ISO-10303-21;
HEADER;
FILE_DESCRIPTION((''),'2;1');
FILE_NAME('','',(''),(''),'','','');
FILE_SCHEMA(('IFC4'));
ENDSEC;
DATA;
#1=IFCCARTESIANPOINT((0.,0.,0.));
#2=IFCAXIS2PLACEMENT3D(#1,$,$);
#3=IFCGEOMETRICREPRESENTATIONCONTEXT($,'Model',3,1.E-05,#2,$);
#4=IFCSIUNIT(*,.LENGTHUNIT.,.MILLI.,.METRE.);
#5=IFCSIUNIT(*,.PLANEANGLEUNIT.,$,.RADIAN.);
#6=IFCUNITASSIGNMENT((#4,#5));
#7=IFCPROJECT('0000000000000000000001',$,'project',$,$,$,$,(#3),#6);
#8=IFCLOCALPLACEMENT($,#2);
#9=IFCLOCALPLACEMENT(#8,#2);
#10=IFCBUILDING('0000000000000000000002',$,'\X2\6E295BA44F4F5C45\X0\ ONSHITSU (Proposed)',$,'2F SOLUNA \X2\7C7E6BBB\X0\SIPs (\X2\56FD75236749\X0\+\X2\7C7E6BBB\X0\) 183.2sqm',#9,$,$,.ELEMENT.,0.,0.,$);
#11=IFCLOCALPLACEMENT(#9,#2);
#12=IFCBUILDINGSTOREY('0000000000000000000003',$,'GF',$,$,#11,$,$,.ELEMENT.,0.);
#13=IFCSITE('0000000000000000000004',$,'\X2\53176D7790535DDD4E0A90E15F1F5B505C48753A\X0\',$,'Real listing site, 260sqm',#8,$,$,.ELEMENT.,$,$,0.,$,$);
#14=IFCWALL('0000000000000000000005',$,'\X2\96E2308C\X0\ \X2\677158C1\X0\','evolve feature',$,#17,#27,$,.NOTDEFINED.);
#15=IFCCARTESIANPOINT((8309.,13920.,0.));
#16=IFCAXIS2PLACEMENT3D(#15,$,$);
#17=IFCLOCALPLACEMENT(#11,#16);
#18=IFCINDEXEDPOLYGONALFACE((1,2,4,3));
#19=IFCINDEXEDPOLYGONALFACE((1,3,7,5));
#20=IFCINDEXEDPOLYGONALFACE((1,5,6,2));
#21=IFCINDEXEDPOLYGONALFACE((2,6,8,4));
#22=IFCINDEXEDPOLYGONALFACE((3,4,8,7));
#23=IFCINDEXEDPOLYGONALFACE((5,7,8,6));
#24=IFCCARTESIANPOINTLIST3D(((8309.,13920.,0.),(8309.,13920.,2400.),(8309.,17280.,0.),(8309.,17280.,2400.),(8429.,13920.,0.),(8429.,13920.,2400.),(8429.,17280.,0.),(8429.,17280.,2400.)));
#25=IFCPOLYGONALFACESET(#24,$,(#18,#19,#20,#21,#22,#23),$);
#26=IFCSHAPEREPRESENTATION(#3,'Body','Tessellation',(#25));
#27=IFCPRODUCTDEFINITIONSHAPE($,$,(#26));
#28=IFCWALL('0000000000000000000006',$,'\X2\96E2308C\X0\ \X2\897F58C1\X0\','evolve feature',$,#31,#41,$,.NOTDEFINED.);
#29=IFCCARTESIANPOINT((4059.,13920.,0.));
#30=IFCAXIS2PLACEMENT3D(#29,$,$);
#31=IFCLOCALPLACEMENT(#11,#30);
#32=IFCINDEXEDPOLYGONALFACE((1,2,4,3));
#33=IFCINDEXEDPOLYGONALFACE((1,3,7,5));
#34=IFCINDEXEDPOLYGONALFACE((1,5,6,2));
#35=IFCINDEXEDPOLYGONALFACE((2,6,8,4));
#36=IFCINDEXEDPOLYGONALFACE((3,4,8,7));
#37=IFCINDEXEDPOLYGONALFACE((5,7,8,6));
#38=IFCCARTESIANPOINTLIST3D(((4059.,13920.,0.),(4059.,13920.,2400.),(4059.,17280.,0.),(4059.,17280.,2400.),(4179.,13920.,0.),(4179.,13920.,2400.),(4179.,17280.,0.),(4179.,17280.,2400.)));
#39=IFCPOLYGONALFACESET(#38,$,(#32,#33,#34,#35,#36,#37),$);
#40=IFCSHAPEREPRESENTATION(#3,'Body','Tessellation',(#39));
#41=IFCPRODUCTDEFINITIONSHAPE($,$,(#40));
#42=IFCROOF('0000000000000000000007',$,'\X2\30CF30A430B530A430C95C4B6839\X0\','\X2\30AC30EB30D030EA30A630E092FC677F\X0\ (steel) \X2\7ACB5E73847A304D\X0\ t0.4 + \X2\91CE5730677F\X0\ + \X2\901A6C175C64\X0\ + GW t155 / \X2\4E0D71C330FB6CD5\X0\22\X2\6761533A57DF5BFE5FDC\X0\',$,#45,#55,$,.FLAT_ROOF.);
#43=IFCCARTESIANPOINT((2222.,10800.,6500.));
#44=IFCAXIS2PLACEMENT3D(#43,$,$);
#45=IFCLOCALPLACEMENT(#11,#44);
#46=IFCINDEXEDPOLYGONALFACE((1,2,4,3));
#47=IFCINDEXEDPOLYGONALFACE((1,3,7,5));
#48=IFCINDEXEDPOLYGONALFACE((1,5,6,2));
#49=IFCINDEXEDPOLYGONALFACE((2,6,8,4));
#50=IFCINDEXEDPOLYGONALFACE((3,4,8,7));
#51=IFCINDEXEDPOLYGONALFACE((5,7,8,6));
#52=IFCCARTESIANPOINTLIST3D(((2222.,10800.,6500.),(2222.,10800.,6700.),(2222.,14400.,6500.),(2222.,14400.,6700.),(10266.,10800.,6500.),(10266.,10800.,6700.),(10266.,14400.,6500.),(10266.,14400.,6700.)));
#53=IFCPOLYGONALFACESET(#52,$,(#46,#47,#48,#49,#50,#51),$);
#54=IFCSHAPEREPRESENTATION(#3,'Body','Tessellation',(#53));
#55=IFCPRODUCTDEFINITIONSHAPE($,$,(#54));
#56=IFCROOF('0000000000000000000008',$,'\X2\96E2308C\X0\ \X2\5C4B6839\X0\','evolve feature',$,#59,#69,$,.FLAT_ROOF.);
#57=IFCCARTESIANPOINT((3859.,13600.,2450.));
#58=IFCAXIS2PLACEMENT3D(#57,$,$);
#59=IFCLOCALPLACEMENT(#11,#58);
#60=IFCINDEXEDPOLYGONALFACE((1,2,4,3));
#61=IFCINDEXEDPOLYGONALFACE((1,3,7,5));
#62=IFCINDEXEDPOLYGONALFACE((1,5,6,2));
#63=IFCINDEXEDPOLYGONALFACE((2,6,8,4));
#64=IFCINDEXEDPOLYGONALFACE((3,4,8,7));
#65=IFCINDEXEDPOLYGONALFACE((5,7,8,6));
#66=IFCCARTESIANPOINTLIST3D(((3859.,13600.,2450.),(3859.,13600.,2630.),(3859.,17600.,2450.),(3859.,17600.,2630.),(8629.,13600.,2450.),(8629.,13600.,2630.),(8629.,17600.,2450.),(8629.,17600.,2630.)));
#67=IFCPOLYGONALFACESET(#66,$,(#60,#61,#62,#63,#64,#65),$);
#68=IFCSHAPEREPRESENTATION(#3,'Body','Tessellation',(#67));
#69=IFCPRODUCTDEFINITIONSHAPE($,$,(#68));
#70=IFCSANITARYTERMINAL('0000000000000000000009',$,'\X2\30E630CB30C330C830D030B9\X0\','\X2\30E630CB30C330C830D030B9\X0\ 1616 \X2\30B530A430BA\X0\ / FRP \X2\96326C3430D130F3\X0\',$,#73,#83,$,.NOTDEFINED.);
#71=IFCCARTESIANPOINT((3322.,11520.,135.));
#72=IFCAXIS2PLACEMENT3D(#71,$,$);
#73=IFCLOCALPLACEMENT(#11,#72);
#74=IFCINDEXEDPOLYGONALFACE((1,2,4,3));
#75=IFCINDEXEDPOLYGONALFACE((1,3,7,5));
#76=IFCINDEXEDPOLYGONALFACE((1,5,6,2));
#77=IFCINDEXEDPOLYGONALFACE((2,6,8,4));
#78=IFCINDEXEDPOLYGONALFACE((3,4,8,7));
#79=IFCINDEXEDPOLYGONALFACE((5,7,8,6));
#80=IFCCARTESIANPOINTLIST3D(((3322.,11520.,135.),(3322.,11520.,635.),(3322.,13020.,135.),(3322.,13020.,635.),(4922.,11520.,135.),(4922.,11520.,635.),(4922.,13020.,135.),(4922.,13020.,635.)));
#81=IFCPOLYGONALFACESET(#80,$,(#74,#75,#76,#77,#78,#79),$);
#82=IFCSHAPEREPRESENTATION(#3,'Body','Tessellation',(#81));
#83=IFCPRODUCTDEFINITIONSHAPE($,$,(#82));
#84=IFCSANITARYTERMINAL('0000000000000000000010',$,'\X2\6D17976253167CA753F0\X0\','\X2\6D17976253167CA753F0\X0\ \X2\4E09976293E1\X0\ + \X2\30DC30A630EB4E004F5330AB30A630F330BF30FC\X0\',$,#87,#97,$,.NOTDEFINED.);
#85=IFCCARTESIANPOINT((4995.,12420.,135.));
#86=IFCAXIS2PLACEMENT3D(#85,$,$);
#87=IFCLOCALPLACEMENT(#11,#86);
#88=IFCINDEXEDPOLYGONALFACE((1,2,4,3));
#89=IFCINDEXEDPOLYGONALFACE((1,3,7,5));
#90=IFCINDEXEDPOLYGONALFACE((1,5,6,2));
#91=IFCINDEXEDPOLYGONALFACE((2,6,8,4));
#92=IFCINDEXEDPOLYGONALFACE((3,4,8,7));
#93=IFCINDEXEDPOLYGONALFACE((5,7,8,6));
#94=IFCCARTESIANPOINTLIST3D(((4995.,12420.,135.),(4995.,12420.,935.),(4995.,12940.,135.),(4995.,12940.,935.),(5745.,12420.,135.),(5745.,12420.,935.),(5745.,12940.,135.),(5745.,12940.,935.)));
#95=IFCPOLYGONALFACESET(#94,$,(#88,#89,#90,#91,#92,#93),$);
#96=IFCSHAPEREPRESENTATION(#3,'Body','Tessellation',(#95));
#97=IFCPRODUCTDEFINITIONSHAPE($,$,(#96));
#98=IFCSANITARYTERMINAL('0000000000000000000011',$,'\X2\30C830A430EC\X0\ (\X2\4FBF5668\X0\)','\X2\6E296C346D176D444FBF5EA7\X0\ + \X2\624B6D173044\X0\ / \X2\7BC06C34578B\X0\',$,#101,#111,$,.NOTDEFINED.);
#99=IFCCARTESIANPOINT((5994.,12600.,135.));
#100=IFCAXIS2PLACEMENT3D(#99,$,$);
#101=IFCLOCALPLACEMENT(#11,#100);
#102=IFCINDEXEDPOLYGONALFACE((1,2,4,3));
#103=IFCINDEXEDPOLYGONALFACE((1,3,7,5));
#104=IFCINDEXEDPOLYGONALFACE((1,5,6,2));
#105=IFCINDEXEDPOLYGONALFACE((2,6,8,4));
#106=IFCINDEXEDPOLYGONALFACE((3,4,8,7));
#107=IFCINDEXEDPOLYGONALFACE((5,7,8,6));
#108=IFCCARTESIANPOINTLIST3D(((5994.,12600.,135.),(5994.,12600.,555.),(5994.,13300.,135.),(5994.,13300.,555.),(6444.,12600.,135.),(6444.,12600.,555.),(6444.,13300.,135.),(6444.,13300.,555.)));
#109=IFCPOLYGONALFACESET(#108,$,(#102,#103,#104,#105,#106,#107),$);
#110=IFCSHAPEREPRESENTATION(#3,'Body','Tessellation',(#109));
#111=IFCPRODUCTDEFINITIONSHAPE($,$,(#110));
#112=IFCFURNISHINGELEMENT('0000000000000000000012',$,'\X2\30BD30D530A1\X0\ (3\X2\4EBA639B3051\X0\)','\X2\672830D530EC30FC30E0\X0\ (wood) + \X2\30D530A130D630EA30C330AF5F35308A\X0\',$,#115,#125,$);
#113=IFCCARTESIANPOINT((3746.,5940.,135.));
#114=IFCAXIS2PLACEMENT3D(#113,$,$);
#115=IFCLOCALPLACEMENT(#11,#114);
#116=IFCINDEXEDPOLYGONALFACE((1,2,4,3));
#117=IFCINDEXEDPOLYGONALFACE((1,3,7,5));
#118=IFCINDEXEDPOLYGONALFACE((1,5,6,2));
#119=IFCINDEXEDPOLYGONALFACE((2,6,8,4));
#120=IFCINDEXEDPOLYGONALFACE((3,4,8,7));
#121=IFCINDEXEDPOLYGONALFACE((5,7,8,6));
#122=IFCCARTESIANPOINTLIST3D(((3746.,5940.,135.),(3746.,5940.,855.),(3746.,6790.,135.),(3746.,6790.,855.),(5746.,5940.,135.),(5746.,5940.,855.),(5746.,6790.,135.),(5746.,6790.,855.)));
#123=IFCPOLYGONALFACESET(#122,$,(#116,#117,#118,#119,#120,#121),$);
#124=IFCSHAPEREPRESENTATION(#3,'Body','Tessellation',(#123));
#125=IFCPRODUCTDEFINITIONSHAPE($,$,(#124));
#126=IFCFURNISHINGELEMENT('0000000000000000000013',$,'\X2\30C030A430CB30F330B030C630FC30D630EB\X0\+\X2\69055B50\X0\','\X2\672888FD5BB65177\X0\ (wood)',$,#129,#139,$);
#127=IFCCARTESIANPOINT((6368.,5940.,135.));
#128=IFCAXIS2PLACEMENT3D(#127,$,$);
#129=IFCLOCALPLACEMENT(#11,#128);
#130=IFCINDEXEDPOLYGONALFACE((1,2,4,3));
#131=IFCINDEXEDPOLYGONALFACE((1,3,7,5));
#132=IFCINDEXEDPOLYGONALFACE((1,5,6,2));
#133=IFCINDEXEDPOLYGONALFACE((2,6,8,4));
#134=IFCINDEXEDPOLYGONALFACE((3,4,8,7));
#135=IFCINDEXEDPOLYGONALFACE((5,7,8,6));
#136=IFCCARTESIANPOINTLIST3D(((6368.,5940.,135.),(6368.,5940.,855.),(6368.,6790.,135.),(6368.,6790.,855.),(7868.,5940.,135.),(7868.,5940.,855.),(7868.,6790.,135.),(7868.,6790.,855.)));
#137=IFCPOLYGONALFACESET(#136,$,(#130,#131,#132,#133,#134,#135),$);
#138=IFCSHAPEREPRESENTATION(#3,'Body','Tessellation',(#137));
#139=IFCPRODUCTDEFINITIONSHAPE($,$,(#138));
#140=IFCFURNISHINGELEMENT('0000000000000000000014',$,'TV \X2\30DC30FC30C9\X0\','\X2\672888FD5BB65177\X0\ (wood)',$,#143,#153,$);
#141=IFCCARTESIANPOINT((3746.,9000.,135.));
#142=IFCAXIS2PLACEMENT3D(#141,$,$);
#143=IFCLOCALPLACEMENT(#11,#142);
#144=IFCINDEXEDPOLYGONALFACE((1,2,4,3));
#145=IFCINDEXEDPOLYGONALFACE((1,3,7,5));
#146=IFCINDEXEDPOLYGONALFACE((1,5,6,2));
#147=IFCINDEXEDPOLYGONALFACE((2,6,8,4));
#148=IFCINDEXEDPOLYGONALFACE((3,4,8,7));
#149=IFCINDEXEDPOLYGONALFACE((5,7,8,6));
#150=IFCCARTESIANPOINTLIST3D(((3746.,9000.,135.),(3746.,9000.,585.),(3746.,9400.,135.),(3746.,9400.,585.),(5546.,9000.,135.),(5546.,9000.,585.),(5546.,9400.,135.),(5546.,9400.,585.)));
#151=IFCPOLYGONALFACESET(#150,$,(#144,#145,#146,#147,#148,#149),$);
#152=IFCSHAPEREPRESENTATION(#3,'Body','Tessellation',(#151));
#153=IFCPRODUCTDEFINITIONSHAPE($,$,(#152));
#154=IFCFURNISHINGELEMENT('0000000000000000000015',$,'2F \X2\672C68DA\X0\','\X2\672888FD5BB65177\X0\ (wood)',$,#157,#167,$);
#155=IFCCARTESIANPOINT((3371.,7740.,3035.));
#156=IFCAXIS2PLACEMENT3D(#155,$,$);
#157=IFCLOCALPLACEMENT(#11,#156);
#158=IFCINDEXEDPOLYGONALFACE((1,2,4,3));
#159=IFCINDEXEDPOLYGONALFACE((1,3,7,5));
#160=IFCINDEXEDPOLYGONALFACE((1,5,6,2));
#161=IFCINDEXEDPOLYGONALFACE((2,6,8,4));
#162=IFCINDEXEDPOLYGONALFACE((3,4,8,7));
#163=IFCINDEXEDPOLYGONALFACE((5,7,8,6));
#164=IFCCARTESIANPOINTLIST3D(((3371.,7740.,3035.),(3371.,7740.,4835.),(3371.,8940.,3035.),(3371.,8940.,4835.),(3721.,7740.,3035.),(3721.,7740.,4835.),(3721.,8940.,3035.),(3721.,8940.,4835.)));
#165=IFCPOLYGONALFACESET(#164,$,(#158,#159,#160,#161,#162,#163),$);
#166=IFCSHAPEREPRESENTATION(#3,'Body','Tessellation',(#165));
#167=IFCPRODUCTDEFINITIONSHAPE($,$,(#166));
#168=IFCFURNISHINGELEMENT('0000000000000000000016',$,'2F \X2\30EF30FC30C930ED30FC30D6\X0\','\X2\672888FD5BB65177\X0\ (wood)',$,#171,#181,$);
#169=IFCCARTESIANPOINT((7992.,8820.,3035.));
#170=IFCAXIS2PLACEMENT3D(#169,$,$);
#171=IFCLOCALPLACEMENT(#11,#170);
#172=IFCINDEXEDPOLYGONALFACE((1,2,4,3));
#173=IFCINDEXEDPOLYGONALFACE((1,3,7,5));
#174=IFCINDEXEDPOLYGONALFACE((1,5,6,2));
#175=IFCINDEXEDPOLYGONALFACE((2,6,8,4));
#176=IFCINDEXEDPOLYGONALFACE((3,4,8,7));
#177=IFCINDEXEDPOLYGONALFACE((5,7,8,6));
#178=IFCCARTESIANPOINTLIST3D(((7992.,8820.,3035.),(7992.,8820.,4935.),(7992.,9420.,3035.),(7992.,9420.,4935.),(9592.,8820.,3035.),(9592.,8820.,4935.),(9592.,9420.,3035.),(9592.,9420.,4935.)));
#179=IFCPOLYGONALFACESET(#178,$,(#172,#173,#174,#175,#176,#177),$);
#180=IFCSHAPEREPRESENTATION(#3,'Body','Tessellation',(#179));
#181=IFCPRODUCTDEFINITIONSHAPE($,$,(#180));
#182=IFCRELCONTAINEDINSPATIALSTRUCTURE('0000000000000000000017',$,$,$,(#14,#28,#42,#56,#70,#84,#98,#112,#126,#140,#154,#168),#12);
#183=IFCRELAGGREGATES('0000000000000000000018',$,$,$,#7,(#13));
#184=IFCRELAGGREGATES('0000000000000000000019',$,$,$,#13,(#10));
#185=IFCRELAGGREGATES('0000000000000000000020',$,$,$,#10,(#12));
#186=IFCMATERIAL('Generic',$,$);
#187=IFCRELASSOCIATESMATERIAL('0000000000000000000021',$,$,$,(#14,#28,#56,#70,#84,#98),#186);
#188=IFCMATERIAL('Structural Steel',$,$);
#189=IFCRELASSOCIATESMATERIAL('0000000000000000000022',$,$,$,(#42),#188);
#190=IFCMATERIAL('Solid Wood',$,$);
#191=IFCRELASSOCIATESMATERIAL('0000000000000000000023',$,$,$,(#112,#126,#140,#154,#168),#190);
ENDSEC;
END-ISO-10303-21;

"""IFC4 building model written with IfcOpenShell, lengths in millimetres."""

from ifc_helpers import new_model, si_unit, frame, frame_2d, origin, place, context, project, spatial, rectangle, extrude, material, element, save


model = new_model("IFC4")

# Units and contexts
model_context = context("Model", 3, precision=1e-05, world=origin())
ifc_project = project(units=[si_unit("LENGTHUNIT", "METRE", prefix="MILLI"), si_unit("PLANEANGLEUNIT", "RADIAN")], contexts=[model_context])

# Site, building, storey
site_placement = place(None, origin())
site = spatial("IfcSite", under=ifc_project, at=site_placement, Name="北海道川上郡弟子屈町", ObjectType="Real listing site, 260sqm", CompositionType="ELEMENT", RefElevation=0.0)
building_placement = place(site_placement, origin())
building = spatial("IfcBuilding", under=site, at=building_placement, Name="温室住居 ONSHITSU (Proposed)", ObjectType="2F SOLUNA 籾殻SIPs (国産杉+籾殻) 183.2sqm", CompositionType="ELEMENT", ElevationOfRefHeight=0.0, ElevationOfTerrain=0.0)
storey_placement = place(building_placement, origin())
storey = spatial("IfcBuildingStorey", under=building, at=storey_placement, Name="GF", CompositionType="ELEMENT", Elevation=0.0)

# Shared definitions
ifc_material_1 = material(Name="Generic")

# Shared definitions
ifc_material_2 = material(Name="Solid Wood")

# Walls
wall_1_placement = place(storey_placement, frame((8309.0, 13920.0, 0.0)))
element("IfcWall", 1, at=wall_1_placement, inside=storey, material=ifc_material_1, Name="離れ 東壁", Description="evolve feature", PredefinedType="NOTDEFINED", context=model_context, shape_type="SweptSolid", body=[
    extrude(rectangle(XDim=120.0, YDim=3360.0, at=frame_2d((60.0, 1680.0))), frame((8309.0, 13920.0, 0.0)), (0.0, 0.0, 1.0), 2400.0),
])
wall_2_placement = place(storey_placement, frame((4059.0, 13920.0, 0.0)))
element("IfcWall", 2, at=wall_2_placement, inside=storey, material=ifc_material_1, Name="離れ 西壁", Description="evolve feature", PredefinedType="NOTDEFINED", context=model_context, shape_type="SweptSolid", body=[
    extrude(rectangle(XDim=120.0, YDim=3360.0, at=frame_2d((60.0, 1680.0))), frame((4059.0, 13920.0, 0.0)), (0.0, 0.0, 1.0), 2400.0),
])

# Roofs
ifc_material_3 = material(Name="Structural Steel")
roof_1_placement = place(storey_placement, frame((2222.0, 10800.0, 6500.0)))
element("IfcRoof", 3, at=roof_1_placement, inside=storey, material=ifc_material_3, Name="ハイサイド屋根", Description="ガルバリウム鋼板 (steel) 立平葺き t0.4 + 野地板 + 通気層 + GW t155 / 不燃・法22条区域対応", PredefinedType="FLAT_ROOF", context=model_context, shape_type="SweptSolid", body=[
    extrude(rectangle(XDim=8044.0, YDim=3600.0, at=frame_2d((4022.0, 1800.0))), frame((2222.0, 10800.0, 6500.0)), (0.0, 0.0, 1.0), 200.0),
])
roof_2_placement = place(storey_placement, frame((3859.0, 13600.0, 2450.0)))
element("IfcRoof", 4, at=roof_2_placement, inside=storey, material=ifc_material_1, Name="離れ 屋根", Description="evolve feature", PredefinedType="FLAT_ROOF", context=model_context, shape_type="SweptSolid", body=[
    extrude(rectangle(XDim=4770.0, YDim=4000.0, at=frame_2d((2385.0, 2000.0))), frame((3859.0, 13600.0, 2450.0)), (0.0, 0.0, 1.0), 180.0),
])

# Sanitary terminals
sanitary_terminal_1_placement = place(storey_placement, frame((3322.0, 11520.0, 135.0)))
element("IfcSanitaryTerminal", 5, at=sanitary_terminal_1_placement, inside=storey, material=ifc_material_1, Name="ユニットバス", Description="ユニットバス 1616 サイズ / FRP 防水パン", PredefinedType="NOTDEFINED", context=model_context, shape_type="SweptSolid", body=[
    extrude(rectangle(XDim=1600.0, YDim=1500.0, at=frame_2d((800.0, 750.0))), frame((3322.0, 11520.0, 135.0)), (0.0, 0.0, 1.0), 500.0),
])
sanitary_terminal_2_placement = place(storey_placement, frame((4995.0, 12420.0, 135.0)))
element("IfcSanitaryTerminal", 6, at=sanitary_terminal_2_placement, inside=storey, material=ifc_material_1, Name="洗面化粧台", Description="洗面化粧台 三面鏡 + ボウル一体カウンター", PredefinedType="NOTDEFINED", context=model_context, shape_type="SweptSolid", body=[
    extrude(rectangle(XDim=750.0, YDim=520.0, at=frame_2d((375.0, 260.0))), frame((4995.0, 12420.0, 135.0)), (0.0, 0.0, 1.0), 800.0),
])
sanitary_terminal_3_placement = place(storey_placement, frame((5994.0, 12600.0, 135.0)))
element("IfcSanitaryTerminal", 7, at=sanitary_terminal_3_placement, inside=storey, material=ifc_material_1, Name="トイレ (便器)", Description="温水洗浄便座 + 手洗い / 節水型", PredefinedType="NOTDEFINED", context=model_context, shape_type="SweptSolid", body=[
    extrude(rectangle(XDim=450.0, YDim=700.0, at=frame_2d((225.0, 350.0))), frame((5994.0, 12600.0, 135.0)), (0.0, 0.0, 1.0), 420.0),
])

# Furnishing elements
furnishing_1_placement = place(storey_placement, frame((3746.0, 5940.0, 135.0)))
element("IfcFurnishingElement", 8, at=furnishing_1_placement, inside=storey, material=ifc_material_2, Name="ソファ (3人掛け)", Description="木フレーム (wood) + ファブリック張り", context=model_context, shape_type="SweptSolid", body=[
    extrude(rectangle(XDim=2000.0, YDim=850.0, at=frame_2d((1000.0, 425.0))), frame((3746.0, 5940.0, 135.0)), (0.0, 0.0, 1.0), 720.0),
])
furnishing_2_placement = place(storey_placement, frame((6368.0, 5940.0, 135.0)))
element("IfcFurnishingElement", 9, at=furnishing_2_placement, inside=storey, material=ifc_material_2, Name="ダイニングテーブル+椅子", Description="木製家具 (wood)", context=model_context, shape_type="SweptSolid", body=[
    extrude(rectangle(XDim=1500.0, YDim=850.0, at=frame_2d((750.0, 425.0))), frame((6368.0, 5940.0, 135.0)), (0.0, 0.0, 1.0), 720.0),
])
furnishing_3_placement = place(storey_placement, frame((3746.0, 9000.0, 135.0)))
element("IfcFurnishingElement", 10, at=furnishing_3_placement, inside=storey, material=ifc_material_2, Name="TV ボード", Description="木製家具 (wood)", context=model_context, shape_type="SweptSolid", body=[
    extrude(rectangle(XDim=1800.0, YDim=400.0, at=frame_2d((900.0, 200.0))), frame((3746.0, 9000.0, 135.0)), (0.0, 0.0, 1.0), 450.0),
])
furnishing_4_placement = place(storey_placement, frame((3371.0, 7740.0, 3035.0)))
element("IfcFurnishingElement", 11, at=furnishing_4_placement, inside=storey, material=ifc_material_2, Name="2F 本棚", Description="木製家具 (wood)", context=model_context, shape_type="SweptSolid", body=[
    extrude(rectangle(XDim=350.0, YDim=1200.0, at=frame_2d((175.0, 600.0))), frame((3371.0, 7740.0, 3035.0)), (0.0, 0.0, 1.0), 1800.0),
])
furnishing_5_placement = place(storey_placement, frame((7992.0, 8820.0, 3035.0)))
element("IfcFurnishingElement", 12, at=furnishing_5_placement, inside=storey, material=ifc_material_2, Name="2F ワードローブ", Description="木製家具 (wood)", context=model_context, shape_type="SweptSolid", body=[
    extrude(rectangle(XDim=1600.0, YDim=600.0, at=frame_2d((800.0, 300.0))), frame((7992.0, 8820.0, 3035.0)), (0.0, 0.0, 1.0), 1900.0),
])

save(model, "model.ifc")
